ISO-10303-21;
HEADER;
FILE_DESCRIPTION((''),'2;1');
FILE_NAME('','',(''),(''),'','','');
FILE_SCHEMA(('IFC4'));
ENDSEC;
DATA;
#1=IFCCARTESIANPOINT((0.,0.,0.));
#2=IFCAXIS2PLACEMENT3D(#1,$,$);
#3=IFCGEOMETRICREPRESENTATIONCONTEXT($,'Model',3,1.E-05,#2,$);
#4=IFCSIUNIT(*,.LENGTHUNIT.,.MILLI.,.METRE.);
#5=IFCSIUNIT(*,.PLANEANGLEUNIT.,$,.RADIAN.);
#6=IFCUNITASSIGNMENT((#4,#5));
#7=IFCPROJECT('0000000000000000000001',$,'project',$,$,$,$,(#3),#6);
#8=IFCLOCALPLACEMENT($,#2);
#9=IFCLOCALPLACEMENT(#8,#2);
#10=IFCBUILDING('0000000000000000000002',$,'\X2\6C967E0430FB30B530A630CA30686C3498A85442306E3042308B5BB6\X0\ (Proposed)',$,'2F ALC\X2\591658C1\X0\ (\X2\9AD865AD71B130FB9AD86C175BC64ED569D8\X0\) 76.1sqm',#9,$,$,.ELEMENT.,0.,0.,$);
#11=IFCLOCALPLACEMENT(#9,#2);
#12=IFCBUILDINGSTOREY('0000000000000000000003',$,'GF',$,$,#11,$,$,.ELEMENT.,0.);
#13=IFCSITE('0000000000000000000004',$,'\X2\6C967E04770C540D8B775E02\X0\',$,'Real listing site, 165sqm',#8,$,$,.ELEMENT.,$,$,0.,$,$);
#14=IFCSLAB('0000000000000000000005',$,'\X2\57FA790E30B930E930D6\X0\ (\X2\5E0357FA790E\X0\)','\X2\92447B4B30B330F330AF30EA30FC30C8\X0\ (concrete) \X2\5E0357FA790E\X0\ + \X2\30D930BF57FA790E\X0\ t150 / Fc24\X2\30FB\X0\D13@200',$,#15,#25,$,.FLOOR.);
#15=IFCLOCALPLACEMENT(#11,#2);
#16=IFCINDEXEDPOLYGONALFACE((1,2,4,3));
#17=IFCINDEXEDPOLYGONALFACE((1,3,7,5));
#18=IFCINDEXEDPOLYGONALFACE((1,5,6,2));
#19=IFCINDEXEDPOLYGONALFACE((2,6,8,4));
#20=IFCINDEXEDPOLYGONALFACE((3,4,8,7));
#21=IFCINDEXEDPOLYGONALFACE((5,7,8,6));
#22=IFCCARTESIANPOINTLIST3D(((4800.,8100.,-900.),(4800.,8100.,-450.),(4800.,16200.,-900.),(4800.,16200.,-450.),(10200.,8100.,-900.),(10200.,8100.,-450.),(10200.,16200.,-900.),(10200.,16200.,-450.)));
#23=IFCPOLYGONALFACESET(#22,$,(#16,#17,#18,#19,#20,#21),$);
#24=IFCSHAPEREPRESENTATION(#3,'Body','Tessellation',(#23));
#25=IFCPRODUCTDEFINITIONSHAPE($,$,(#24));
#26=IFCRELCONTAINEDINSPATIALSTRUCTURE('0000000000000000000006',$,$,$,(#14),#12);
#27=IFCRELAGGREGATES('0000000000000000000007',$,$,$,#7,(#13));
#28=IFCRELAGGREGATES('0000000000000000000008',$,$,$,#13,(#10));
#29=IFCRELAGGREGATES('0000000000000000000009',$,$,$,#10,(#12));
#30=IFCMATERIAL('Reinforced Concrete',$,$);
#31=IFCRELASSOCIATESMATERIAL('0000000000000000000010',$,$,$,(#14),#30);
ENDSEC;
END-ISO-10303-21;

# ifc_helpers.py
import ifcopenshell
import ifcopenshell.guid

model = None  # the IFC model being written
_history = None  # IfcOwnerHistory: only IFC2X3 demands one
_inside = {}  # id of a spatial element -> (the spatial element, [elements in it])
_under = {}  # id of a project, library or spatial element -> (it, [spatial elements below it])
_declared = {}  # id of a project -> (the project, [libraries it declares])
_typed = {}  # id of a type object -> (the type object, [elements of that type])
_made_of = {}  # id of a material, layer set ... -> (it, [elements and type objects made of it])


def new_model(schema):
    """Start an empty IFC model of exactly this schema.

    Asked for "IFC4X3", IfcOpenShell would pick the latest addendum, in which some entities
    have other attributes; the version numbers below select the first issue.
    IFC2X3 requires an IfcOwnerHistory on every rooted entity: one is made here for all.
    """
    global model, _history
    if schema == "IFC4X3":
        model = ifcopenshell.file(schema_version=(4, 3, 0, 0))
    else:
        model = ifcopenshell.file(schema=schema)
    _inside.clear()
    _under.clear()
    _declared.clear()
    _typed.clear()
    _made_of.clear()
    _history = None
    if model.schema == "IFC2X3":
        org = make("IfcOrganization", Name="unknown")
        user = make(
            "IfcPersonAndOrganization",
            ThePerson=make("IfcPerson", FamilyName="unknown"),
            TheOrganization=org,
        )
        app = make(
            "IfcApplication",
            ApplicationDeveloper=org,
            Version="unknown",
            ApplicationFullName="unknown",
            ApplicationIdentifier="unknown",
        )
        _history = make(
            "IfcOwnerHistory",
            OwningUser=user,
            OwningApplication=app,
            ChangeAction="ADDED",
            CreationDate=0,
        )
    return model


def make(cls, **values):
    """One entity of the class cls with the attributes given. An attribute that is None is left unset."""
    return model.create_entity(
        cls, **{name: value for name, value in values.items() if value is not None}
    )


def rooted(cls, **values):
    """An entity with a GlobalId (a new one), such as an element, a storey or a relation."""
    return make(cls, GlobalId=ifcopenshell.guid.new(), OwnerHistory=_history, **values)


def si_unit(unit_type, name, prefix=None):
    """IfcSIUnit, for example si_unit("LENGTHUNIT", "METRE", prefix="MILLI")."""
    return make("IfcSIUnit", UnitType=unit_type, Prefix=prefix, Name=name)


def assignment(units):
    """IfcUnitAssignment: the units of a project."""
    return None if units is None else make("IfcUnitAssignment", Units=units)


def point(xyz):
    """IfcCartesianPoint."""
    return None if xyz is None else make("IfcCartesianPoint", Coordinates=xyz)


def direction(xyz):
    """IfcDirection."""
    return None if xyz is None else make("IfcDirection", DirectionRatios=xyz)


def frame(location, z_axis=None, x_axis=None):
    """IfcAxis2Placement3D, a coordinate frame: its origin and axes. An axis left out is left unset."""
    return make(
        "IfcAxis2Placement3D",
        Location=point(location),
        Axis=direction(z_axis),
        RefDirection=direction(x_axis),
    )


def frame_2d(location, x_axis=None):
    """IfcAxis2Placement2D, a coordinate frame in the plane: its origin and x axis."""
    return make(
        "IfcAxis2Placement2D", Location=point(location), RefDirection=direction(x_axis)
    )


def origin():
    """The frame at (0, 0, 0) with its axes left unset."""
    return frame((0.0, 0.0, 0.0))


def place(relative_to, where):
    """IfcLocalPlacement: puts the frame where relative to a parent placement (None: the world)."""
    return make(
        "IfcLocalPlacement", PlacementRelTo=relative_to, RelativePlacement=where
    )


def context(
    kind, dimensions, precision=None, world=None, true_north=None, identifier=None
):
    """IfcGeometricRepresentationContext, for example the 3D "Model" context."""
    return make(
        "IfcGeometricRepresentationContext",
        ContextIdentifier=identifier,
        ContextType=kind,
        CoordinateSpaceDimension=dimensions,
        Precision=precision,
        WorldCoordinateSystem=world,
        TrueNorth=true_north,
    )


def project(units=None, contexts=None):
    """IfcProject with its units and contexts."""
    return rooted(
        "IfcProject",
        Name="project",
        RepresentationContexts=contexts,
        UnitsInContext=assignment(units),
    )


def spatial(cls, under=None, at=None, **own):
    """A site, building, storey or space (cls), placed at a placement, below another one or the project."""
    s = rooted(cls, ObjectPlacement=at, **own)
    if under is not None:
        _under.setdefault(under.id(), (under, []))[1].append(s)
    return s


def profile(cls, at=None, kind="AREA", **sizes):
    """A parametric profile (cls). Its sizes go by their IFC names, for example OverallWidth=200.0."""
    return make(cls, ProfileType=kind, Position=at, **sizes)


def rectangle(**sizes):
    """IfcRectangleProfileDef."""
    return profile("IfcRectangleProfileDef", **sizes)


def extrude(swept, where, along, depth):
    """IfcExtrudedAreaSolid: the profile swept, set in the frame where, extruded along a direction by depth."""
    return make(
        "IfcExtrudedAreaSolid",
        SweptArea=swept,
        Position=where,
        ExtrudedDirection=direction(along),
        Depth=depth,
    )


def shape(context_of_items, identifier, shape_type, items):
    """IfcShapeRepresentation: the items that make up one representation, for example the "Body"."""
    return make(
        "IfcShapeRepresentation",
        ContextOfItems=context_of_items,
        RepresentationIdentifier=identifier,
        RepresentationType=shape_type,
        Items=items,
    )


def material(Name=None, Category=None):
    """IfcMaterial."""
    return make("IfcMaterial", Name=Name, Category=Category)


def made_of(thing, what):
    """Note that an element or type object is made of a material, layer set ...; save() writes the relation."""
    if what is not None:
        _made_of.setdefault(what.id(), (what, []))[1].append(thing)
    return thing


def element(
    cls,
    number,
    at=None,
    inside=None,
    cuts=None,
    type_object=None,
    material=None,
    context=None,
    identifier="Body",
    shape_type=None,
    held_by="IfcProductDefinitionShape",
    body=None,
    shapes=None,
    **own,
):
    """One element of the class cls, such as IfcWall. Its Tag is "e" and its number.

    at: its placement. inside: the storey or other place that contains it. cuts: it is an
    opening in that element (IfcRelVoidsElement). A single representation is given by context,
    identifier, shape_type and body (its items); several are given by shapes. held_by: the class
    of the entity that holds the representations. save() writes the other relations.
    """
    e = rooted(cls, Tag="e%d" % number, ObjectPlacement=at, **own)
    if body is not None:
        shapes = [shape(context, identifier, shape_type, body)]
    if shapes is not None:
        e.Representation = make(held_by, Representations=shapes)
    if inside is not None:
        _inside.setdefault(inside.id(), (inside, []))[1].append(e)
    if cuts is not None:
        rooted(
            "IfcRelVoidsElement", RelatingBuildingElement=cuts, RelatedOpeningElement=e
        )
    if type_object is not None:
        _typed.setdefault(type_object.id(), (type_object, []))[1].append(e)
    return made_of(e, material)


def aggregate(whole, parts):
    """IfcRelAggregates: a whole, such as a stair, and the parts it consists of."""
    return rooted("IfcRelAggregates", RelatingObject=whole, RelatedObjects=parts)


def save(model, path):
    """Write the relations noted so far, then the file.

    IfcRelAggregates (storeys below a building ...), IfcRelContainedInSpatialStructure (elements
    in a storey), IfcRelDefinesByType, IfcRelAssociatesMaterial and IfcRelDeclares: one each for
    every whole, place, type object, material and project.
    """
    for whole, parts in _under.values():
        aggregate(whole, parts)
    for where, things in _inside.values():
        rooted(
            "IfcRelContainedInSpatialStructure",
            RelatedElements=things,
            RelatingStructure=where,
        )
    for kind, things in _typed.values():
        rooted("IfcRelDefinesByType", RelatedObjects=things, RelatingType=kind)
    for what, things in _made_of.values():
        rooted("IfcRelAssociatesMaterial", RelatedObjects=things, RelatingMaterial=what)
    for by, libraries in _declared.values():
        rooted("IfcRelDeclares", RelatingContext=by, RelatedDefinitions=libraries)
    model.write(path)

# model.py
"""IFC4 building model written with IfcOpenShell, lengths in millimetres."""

from ifc_helpers import new_model, si_unit, frame, frame_2d, origin, place, context, project, spatial, rectangle, extrude, material, element, save


model = new_model("IFC4")

# Units and contexts
model_context = context("Model", 3, precision=1e-05, world=origin())
ifc_project = project(units=[si_unit("LENGTHUNIT", "METRE", prefix="MILLI"), si_unit("PLANEANGLEUNIT", "RADIAN")], contexts=[model_context])

# Site, building, storey
site_placement = place(None, origin())
site = spatial("IfcSite", under=ifc_project, at=site_placement, Name="沖縄県名護市", ObjectType="Real listing site, 165sqm", CompositionType="ELEMENT", RefElevation=0.0)
building_placement = place(site_placement, origin())
building = spatial("IfcBuilding", under=site, at=building_placement, Name="沖縄・サウナと水風呂のある家 (Proposed)", ObjectType="2F ALC外壁 (高断熱・高気密仕様) 76.1sqm", CompositionType="ELEMENT", ElevationOfRefHeight=0.0, ElevationOfTerrain=0.0)
storey_placement = place(building_placement, origin())
storey = spatial("IfcBuildingStorey", under=building, at=storey_placement, Name="GF", CompositionType="ELEMENT", Elevation=0.0)

# Slab
ifc_material_1 = material(Name="Reinforced Concrete")
slab_1_placement = place(storey_placement, frame((2400.0, 4050.0, -450.0)))
element("IfcSlab", 1, at=slab_1_placement, inside=storey, material=ifc_material_1, Name="基礎スラブ (布基礎)", Description="鉄筋コンクリート (concrete) 布基礎 + ベタ基礎 t150 / Fc24・D13@200", PredefinedType="FLOOR", context=model_context, shape_type="SweptSolid", body=[
    extrude(rectangle(XDim=5400.0, YDim=8100.0, at=frame_2d((2700.0, 4050.0))), frame((2400.0, 4050.0, -450.0)), (0.0, 0.0, 1.0), 450.0),
])

save(model, "model.ifc")
